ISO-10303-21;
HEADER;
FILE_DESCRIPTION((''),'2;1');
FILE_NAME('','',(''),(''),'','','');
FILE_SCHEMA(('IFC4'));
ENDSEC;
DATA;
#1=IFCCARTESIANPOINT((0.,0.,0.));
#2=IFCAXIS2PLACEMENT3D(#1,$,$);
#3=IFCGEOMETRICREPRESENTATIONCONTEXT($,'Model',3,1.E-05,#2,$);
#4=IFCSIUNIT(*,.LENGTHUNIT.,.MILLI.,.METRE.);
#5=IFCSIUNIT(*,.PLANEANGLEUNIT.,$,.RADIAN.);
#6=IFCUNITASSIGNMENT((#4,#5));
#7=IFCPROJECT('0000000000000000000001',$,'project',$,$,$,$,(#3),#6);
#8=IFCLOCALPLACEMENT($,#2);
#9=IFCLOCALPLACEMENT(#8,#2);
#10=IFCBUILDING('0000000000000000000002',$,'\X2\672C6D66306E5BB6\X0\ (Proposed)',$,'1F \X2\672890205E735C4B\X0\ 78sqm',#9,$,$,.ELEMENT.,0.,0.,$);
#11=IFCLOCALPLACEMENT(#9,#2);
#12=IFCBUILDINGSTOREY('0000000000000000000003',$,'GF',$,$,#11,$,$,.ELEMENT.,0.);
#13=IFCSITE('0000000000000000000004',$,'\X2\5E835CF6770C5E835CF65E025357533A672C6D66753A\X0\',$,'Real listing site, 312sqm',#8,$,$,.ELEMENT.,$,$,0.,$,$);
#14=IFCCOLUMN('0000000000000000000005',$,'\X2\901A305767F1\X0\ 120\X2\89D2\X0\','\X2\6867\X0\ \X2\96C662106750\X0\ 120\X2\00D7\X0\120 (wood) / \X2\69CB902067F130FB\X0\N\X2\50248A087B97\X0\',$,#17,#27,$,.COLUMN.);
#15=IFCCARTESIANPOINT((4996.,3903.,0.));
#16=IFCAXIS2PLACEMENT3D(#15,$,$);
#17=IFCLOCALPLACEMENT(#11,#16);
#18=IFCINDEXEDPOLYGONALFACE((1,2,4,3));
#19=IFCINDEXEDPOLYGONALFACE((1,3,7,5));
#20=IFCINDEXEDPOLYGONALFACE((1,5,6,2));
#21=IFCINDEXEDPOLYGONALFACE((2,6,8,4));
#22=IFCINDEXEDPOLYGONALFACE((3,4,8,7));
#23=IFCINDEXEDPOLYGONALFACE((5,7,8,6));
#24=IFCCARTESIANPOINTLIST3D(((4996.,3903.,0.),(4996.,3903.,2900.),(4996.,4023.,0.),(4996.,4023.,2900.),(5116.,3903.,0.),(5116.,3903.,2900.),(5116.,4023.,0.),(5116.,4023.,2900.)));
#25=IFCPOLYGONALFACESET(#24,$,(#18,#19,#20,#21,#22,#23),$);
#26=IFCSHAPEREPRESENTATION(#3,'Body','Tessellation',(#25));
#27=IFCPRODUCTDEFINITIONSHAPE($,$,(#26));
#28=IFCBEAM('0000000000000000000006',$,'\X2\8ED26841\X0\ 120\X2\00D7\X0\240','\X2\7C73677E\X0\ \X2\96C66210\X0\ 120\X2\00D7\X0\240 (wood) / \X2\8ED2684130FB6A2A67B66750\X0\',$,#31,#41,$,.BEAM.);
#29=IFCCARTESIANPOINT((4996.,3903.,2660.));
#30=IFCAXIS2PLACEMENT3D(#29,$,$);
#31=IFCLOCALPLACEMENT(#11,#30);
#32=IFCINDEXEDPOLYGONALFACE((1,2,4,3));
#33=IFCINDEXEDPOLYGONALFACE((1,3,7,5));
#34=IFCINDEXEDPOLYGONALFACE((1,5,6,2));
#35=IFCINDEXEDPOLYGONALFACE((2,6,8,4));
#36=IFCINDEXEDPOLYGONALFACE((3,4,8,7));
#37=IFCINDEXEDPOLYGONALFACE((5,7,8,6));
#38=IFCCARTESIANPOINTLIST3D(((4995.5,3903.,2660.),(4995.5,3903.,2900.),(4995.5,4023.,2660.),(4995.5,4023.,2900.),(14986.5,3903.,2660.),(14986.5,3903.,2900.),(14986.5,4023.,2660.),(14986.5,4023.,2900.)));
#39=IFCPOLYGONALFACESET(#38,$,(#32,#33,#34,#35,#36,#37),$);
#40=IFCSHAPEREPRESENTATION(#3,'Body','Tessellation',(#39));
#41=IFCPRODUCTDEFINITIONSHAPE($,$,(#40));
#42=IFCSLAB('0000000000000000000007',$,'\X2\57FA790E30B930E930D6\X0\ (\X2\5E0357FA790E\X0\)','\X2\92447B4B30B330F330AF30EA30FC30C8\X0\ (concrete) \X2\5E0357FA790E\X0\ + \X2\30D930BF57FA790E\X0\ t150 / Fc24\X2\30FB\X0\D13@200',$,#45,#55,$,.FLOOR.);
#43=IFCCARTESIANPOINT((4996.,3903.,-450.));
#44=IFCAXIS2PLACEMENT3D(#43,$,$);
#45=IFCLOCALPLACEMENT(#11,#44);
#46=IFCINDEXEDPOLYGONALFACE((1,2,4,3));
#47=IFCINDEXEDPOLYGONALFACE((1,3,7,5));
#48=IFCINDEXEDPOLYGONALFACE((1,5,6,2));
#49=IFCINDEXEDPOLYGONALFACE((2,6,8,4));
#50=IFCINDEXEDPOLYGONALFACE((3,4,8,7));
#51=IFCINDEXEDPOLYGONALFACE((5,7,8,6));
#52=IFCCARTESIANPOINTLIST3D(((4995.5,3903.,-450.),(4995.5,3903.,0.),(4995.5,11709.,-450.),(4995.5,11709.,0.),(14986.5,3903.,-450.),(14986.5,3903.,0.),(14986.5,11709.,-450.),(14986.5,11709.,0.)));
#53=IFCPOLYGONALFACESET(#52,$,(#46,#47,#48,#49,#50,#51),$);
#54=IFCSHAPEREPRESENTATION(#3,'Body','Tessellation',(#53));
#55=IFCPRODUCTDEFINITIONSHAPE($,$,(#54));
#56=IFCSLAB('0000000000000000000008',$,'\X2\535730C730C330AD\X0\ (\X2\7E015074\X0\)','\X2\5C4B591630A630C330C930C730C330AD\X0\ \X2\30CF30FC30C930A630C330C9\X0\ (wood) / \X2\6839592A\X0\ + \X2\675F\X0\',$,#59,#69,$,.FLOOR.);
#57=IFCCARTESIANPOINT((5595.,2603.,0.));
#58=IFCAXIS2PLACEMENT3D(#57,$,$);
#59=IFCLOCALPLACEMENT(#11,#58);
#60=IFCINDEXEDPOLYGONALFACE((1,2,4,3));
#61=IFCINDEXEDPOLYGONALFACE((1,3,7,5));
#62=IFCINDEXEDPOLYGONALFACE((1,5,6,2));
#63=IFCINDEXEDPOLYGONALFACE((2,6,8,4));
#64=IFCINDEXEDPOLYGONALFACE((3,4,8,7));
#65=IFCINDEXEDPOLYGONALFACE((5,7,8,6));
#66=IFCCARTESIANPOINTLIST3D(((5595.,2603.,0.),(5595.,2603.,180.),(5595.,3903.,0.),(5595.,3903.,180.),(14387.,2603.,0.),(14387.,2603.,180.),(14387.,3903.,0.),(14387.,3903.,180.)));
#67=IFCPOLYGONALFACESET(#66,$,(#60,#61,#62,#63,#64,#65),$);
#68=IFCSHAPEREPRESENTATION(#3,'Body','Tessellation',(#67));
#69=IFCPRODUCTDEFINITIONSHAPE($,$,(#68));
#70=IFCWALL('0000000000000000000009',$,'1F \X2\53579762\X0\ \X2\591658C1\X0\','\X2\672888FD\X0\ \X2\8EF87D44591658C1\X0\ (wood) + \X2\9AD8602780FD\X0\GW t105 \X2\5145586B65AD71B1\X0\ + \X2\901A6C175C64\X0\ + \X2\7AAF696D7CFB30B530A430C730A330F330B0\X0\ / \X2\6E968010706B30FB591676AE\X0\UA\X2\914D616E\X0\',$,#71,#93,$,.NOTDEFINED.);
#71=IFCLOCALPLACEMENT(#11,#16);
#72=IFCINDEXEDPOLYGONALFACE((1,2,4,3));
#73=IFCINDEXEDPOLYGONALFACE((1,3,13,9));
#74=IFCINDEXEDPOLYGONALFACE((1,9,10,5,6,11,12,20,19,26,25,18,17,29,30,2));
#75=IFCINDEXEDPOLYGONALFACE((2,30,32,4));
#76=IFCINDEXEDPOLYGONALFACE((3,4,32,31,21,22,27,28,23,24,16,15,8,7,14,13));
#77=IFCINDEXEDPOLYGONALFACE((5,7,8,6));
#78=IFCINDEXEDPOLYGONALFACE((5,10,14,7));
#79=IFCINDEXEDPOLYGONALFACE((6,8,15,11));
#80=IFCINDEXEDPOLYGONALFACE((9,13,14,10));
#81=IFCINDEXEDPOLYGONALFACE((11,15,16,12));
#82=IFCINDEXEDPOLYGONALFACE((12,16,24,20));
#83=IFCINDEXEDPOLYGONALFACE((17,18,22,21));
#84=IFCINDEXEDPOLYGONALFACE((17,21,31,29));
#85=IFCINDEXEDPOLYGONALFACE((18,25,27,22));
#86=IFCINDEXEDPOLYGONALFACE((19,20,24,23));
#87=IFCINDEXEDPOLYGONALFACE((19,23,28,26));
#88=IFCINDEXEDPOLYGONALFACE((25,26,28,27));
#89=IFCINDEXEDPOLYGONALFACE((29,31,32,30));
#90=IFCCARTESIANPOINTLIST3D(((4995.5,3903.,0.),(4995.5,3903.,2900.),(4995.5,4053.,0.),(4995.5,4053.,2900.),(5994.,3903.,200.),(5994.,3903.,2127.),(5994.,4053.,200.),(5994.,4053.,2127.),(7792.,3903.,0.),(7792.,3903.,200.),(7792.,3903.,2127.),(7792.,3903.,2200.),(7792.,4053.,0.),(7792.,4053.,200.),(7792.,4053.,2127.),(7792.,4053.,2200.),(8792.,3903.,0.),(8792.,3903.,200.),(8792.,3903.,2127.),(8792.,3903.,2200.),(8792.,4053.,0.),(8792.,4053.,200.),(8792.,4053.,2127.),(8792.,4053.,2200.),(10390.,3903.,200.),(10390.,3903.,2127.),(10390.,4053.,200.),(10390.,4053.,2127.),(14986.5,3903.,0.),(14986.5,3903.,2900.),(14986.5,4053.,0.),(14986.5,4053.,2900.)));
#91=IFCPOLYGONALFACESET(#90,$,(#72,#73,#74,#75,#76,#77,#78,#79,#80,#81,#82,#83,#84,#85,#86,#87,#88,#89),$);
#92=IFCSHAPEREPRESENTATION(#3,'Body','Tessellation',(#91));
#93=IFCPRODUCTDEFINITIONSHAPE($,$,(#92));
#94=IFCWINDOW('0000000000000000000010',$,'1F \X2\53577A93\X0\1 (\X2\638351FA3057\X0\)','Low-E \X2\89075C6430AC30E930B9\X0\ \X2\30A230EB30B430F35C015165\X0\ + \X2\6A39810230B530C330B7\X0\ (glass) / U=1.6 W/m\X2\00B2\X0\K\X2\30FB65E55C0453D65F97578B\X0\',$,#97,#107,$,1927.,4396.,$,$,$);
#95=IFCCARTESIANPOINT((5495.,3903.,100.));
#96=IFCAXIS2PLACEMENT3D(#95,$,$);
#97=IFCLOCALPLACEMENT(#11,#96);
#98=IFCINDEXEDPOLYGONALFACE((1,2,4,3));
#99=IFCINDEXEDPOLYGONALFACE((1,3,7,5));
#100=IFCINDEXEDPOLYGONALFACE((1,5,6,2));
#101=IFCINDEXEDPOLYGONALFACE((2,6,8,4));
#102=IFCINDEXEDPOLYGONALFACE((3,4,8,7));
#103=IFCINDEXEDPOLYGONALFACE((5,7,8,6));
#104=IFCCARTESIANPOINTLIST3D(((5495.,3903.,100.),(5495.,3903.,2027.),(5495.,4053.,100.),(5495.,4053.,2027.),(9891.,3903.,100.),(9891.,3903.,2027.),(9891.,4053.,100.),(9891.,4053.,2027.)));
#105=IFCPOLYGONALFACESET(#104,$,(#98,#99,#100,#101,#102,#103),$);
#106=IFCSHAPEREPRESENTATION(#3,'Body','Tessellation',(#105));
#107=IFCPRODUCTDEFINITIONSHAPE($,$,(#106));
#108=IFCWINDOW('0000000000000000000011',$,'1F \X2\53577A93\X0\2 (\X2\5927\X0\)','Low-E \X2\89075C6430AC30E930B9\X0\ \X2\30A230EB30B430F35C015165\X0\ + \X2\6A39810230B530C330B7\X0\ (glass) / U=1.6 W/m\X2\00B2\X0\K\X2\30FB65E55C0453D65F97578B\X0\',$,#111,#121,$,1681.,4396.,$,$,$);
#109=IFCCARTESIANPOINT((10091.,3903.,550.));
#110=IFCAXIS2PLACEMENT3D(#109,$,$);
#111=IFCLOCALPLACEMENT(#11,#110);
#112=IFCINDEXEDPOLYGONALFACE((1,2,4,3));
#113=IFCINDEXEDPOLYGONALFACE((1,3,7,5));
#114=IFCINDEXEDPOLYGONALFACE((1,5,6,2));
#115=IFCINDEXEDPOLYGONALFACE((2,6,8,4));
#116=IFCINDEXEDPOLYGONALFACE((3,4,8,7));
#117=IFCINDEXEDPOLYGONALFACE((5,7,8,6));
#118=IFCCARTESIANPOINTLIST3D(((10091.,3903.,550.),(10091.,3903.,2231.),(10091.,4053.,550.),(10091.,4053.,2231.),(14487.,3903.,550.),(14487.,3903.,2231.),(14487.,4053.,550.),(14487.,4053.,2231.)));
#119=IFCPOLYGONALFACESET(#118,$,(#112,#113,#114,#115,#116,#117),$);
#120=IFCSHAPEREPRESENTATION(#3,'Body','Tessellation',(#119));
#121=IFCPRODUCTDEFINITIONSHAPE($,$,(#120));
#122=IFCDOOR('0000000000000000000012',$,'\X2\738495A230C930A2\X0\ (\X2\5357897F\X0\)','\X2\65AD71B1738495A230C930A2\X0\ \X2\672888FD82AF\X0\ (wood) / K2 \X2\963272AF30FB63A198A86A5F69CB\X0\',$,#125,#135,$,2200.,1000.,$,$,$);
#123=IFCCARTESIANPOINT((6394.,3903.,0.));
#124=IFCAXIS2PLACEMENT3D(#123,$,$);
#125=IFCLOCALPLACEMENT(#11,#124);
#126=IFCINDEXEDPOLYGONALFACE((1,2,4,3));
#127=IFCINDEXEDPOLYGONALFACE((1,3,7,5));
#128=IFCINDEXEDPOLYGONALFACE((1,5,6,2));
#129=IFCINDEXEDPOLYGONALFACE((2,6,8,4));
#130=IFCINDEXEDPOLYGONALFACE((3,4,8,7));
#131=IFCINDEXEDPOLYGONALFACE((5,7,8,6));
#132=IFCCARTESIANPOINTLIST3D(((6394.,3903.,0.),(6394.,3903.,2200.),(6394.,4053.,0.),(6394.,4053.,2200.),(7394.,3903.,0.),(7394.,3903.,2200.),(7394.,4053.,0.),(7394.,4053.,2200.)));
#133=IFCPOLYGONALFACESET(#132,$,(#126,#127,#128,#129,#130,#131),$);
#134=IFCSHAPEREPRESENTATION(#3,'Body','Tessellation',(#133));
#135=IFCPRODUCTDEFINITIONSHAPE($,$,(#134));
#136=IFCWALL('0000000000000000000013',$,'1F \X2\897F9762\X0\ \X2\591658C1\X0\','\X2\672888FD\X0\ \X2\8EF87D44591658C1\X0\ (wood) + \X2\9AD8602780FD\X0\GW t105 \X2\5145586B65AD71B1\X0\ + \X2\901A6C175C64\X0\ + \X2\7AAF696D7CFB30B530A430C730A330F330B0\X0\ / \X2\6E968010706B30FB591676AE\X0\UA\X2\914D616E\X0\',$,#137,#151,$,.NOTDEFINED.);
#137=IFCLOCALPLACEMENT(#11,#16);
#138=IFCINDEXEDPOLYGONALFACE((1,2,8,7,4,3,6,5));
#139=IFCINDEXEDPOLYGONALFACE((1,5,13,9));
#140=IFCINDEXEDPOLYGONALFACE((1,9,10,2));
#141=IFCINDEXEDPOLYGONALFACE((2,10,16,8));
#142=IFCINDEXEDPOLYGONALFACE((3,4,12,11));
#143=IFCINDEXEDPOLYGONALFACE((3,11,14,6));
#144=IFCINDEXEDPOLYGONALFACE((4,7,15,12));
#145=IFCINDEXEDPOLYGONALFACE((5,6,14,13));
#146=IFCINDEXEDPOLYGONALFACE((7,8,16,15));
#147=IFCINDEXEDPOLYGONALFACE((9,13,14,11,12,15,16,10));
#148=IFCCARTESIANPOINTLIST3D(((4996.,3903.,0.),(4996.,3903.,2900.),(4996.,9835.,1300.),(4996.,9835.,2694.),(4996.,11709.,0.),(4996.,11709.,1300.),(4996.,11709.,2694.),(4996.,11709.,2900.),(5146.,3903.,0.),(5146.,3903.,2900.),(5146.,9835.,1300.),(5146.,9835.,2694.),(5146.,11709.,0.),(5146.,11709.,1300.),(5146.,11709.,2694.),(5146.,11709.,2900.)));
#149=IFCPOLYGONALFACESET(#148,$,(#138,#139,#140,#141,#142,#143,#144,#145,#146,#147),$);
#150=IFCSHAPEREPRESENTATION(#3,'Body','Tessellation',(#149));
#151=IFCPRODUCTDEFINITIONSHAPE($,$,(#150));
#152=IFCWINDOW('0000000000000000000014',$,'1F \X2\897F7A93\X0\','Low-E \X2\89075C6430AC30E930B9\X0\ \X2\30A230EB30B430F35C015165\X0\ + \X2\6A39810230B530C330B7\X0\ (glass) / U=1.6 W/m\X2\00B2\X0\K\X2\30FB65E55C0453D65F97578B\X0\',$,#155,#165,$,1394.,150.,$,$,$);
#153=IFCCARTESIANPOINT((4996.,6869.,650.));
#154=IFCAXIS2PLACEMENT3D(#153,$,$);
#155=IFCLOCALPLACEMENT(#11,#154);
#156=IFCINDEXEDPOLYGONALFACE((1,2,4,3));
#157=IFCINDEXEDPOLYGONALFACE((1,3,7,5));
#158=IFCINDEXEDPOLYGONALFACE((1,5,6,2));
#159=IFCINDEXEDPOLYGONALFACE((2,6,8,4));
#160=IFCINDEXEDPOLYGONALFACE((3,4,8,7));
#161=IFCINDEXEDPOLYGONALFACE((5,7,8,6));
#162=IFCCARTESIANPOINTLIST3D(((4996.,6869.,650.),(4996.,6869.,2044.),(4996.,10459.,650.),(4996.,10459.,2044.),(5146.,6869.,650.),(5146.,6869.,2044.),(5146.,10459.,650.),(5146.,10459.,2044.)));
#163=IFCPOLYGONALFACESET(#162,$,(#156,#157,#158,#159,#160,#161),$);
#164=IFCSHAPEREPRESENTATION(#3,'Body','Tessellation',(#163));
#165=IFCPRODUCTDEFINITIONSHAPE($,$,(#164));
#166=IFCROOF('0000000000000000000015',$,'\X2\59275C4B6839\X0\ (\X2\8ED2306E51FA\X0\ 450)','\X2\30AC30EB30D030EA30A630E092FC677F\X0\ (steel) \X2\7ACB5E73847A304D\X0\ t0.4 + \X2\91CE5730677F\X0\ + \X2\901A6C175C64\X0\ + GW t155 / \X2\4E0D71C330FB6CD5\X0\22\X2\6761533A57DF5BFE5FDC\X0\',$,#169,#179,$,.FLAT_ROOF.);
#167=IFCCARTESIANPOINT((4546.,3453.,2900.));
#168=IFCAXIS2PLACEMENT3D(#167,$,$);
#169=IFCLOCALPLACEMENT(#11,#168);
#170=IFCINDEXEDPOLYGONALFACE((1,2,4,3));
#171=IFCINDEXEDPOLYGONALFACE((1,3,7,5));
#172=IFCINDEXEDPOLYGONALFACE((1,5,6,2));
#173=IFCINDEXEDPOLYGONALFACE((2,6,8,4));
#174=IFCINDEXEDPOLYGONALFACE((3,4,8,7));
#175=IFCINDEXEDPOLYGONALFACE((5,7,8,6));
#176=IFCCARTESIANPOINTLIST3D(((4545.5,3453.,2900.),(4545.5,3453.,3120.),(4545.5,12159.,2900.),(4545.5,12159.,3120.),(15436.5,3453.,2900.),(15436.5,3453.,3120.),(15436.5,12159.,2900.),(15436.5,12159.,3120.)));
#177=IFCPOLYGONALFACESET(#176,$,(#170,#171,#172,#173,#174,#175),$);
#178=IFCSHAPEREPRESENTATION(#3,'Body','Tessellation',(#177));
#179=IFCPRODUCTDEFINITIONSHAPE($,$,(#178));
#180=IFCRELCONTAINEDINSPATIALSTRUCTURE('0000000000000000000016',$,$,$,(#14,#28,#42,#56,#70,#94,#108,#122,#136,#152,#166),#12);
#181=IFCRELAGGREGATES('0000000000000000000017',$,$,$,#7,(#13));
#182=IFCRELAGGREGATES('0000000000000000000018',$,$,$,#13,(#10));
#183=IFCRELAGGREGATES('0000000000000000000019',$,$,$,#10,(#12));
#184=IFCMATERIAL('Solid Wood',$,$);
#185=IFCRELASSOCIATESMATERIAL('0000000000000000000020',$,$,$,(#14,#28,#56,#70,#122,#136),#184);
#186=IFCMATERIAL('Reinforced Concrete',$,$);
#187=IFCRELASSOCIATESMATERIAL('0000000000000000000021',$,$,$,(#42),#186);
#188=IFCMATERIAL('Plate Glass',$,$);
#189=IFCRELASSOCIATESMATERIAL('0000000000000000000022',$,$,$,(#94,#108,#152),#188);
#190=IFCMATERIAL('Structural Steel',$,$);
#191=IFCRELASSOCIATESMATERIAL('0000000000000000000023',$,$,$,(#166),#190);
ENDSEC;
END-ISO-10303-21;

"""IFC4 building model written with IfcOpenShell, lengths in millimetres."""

from ifc_helpers import new_model, si_unit, frame, frame_2d, origin, place, context, project, spatial, rectangle, extrude, material, element, fill, save


model = new_model("IFC4")

# Units and contexts
model_context = context("Model", 3, precision=1e-05, world=origin())
ifc_project = project(units=[si_unit("LENGTHUNIT", "METRE", prefix="MILLI"), si_unit("PLANEANGLEUNIT", "RADIAN")], contexts=[model_context])

# Site, building, storey
site_placement = place(None, origin())
site = spatial("IfcSite", under=ifc_project, at=site_placement, Name="広島県広島市南区本浦町", ObjectType="Real listing site, 312sqm", CompositionType="ELEMENT", RefElevation=0.0)
building_placement = place(site_placement, origin())
building = spatial("IfcBuilding", under=site, at=building_placement, Name="本浦の家 (Proposed)", ObjectType="1F 木造平屋 78sqm", CompositionType="ELEMENT", ElevationOfRefHeight=0.0, ElevationOfTerrain=0.0)
storey_placement = place(building_placement, origin())
storey = spatial("IfcBuildingStorey", under=building, at=storey_placement, Name="GF", CompositionType="ELEMENT", Elevation=0.0)

# Column
ifc_material_1 = material(Name="Solid Wood")
column_1_placement = place(storey_placement, frame((4996.0, 3903.0, 0.0)))
element("IfcColumn", 1, at=column_1_placement, inside=storey, material=ifc_material_1, Name="通し柱 120角", Description="桧 集成材 120×120 (wood) / 構造柱・N値計算", PredefinedType="COLUMN", context=model_context, shape_type="SweptSolid", body=[
    extrude(rectangle(XDim=120.0, YDim=120.0, at=frame_2d((60.0, 60.0))), frame((4996.0, 3903.0, 0.0)), (0.0, 0.0, 1.0), 2900.0),
])

# Beam
beam_1_placement = place(storey_placement, frame((4996.0, 3903.0, 2660.0)))
element("IfcBeam", 2, at=beam_1_placement, inside=storey, material=ifc_material_1, Name="軒桁 120×240", Description="米松 集成 120×240 (wood) / 軒桁・横架材", PredefinedType="BEAM", context=model_context, shape_type="SweptSolid", body=[
    extrude(rectangle(XDim=9991.0, YDim=120.0, at=frame_2d((4995.0, 60.0))), frame((4996.0, 3903.0, 2660.0)), (0.0, 0.0, 1.0), 240.0),
])

# Slabs
ifc_material_2 = material(Name="Reinforced Concrete")
slab_1_placement = place(storey_placement, frame((4996.0, 3903.0, -450.0)))
element("IfcSlab", 3, at=slab_1_placement, inside=storey, material=ifc_material_2, Name="基礎スラブ (布基礎)", Description="鉄筋コンクリート (concrete) 布基礎 + ベタ基礎 t150 / Fc24・D13@200", PredefinedType="FLOOR", context=model_context, shape_type="SweptSolid", body=[
    extrude(rectangle(XDim=9991.0, YDim=7806.0, at=frame_2d((4995.0, 3903.0))), frame((4996.0, 3903.0, -450.0)), (0.0, 0.0, 1.0), 450.0),
])
slab_2_placement = place(storey_placement, frame((5595.0, 2603.0, 0.0)))
element("IfcSlab", 4, at=slab_2_placement, inside=storey, material=ifc_material_1, Name="南デッキ (縁側)", Description="屋外ウッドデッキ ハードウッド (wood) / 根太 + 束", PredefinedType="FLOOR", context=model_context, shape_type="SweptSolid", body=[
    extrude(rectangle(XDim=8792.0, YDim=1300.0, at=frame_2d((4396.0, 650.0))), frame((5595.0, 2603.0, 0.0)), (0.0, 0.0, 1.0), 180.0),
])

# Wall, openings, windows, door
wall_1_placement = place(storey_placement, frame((4996.0, 3903.0, 0.0)))
wall_1 = element("IfcWall", 5, at=wall_1_placement, inside=storey, material=ifc_material_1, Name="1F 南面 外壁", Description="木製 軸組外壁 (wood) + 高性能GW t105 充填断熱 + 通気層 + 窯業系サイディング / 準耐火・外皮UA配慮", PredefinedType="NOTDEFINED", context=model_context, shape_type="SweptSolid", body=[
    extrude(rectangle(XDim=9991.0, YDim=150.0, at=frame_2d((4995.0, 75.0))), frame((4996.0, 3903.0, 0.0)), (0.0, 0.0, 1.0), 2900.0),
])
opening_1_placement = place(storey_placement, frame((5495.0, 3903.0, 100.0)))
opening_1 = element("IfcOpeningElement", 6, at=opening_1_placement, cuts=wall_1, PredefinedType="NOTDEFINED", context=model_context, shape_type="SweptSolid", body=[
    extrude(rectangle(XDim=4396.0, YDim=150.0, at=frame_2d((2198.0, 75.0))), frame((5495.0, 3903.0, 100.0)), (0.0, 0.0, 1.0), 1927.0),
])
opening_2_placement = place(storey_placement, frame((10091.0, 3903.0, 550.0)))
opening_2 = element("IfcOpeningElement", 7, at=opening_2_placement, cuts=wall_1, PredefinedType="NOTDEFINED", context=model_context, shape_type="SweptSolid", body=[
    extrude(rectangle(XDim=4396.0, YDim=150.0, at=frame_2d((2198.0, 75.0))), frame((10091.0, 3903.0, 550.0)), (0.0, 0.0, 1.0), 1681.0),
])
opening_3_placement = place(storey_placement, frame((6394.0, 3903.0, 0.0)))
opening_3 = element("IfcOpeningElement", 8, at=opening_3_placement, cuts=wall_1, PredefinedType="NOTDEFINED", context=model_context, shape_type="SweptSolid", body=[
    extrude(rectangle(XDim=1000.0, YDim=150.0, at=frame_2d((500.0, 75.0))), frame((6394.0, 3903.0, 0.0)), (0.0, 0.0, 1.0), 2200.0),
])
ifc_material_3 = material(Name="Plate Glass")
window_1_placement = place(storey_placement, frame((5495.0, 3903.0, 100.0)))
window_1 = element("IfcWindow", 9, at=window_1_placement, inside=storey, material=ifc_material_3, Name="1F 南窓1 (掃出し)", Description="Low-E 複層ガラス アルゴン封入 + 樹脂サッシ (glass) / U=1.6 W/m²K・日射取得型", OverallHeight=1927.0, OverallWidth=4396.0, context=model_context, shape_type="SweptSolid", body=[
    extrude(rectangle(XDim=4396.0, YDim=150.0, at=frame_2d((2198.0, 75.0))), frame((5495.0, 3903.0, 100.0)), (0.0, 0.0, 1.0), 1927.0),
])
fill(opening_1, window_1)
window_2_placement = place(storey_placement, frame((10091.0, 3903.0, 550.0)))
window_2 = element("IfcWindow", 10, at=window_2_placement, inside=storey, material=ifc_material_3, Name="1F 南窓2 (大)", Description="Low-E 複層ガラス アルゴン封入 + 樹脂サッシ (glass) / U=1.6 W/m²K・日射取得型", OverallHeight=1681.0, OverallWidth=4396.0, context=model_context, shape_type="SweptSolid", body=[
    extrude(rectangle(XDim=4396.0, YDim=150.0, at=frame_2d((2198.0, 75.0))), frame((10091.0, 3903.0, 550.0)), (0.0, 0.0, 1.0), 1681.0),
])
fill(opening_2, window_2)
door_placement = place(storey_placement, frame((6394.0, 3903.0, 0.0)))
door = element("IfcDoor", 11, at=door_placement, inside=storey, material=ifc_material_1, Name="玄関ドア (南西)", Description="断熱玄関ドア 木製芯 (wood) / K2 防犯・採風機構", OverallHeight=2200.0, OverallWidth=1000.0, context=model_context, shape_type="SweptSolid", body=[
    extrude(rectangle(XDim=1000.0, YDim=150.0, at=frame_2d((500.0, 75.0))), frame((6394.0, 3903.0, 0.0)), (0.0, 0.0, 1.0), 2200.0),
])
fill(opening_3, door)

# Wall, opening, window
wall_2_placement = place(storey_placement, frame((4996.0, 3903.0, 0.0)))
wall_2 = element("IfcWall", 12, at=wall_2_placement, inside=storey, material=ifc_material_1, Name="1F 西面 外壁", Description="木製 軸組外壁 (wood) + 高性能GW t105 充填断熱 + 通気層 + 窯業系サイディング / 準耐火・外皮UA配慮", PredefinedType="NOTDEFINED", context=model_context, shape_type="SweptSolid", body=[
    extrude(rectangle(XDim=150.0, YDim=7806.0, at=frame_2d((75.0, 3903.0))), frame((4996.0, 3903.0, 0.0)), (0.0, 0.0, 1.0), 2900.0),
])
opening_4_placement = place(storey_placement, frame((4996.0, 6869.0, 650.0)))
opening_4 = element("IfcOpeningElement", 13, at=opening_4_placement, cuts=wall_2, PredefinedType="NOTDEFINED", context=model_context, shape_type="SweptSolid", body=[
    extrude(rectangle(XDim=150.0, YDim=3590.0, at=frame_2d((75.0, 1795.0))), frame((4996.0, 6869.0, 650.0)), (0.0, 0.0, 1.0), 1394.0),
])
window_3_placement = place(storey_placement, frame((4996.0, 6869.0, 650.0)))
window_3 = element("IfcWindow", 14, at=window_3_placement, inside=storey, material=ifc_material_3, Name="1F 西窓", Description="Low-E 複層ガラス アルゴン封入 + 樹脂サッシ (glass) / U=1.6 W/m²K・日射取得型", OverallHeight=1394.0, OverallWidth=150.0, context=model_context, shape_type="SweptSolid", body=[
    extrude(rectangle(XDim=150.0, YDim=3590.0, at=frame_2d((75.0, 1795.0))), frame((4996.0, 6869.0, 650.0)), (0.0, 0.0, 1.0), 1394.0),
])
fill(opening_4, window_3)

# Roof
ifc_material_4 = material(Name="Structural Steel")
roof_placement = place(storey_placement, frame((4546.0, 3453.0, 2900.0)))
element("IfcRoof", 15, at=roof_placement, inside=storey, material=ifc_material_4, Name="大屋根 (軒の出 450)", Description="ガルバリウム鋼板 (steel) 立平葺き t0.4 + 野地板 + 通気層 + GW t155 / 不燃・法22条区域対応", PredefinedType="FLAT_ROOF", context=model_context, shape_type="SweptSolid", body=[
    extrude(rectangle(XDim=10891.0, YDim=8706.0, at=frame_2d((5445.0, 4353.0))), frame((4546.0, 3453.0, 2900.0)), (0.0, 0.0, 1.0), 220.0),
])

save(model, "model.ifc")
